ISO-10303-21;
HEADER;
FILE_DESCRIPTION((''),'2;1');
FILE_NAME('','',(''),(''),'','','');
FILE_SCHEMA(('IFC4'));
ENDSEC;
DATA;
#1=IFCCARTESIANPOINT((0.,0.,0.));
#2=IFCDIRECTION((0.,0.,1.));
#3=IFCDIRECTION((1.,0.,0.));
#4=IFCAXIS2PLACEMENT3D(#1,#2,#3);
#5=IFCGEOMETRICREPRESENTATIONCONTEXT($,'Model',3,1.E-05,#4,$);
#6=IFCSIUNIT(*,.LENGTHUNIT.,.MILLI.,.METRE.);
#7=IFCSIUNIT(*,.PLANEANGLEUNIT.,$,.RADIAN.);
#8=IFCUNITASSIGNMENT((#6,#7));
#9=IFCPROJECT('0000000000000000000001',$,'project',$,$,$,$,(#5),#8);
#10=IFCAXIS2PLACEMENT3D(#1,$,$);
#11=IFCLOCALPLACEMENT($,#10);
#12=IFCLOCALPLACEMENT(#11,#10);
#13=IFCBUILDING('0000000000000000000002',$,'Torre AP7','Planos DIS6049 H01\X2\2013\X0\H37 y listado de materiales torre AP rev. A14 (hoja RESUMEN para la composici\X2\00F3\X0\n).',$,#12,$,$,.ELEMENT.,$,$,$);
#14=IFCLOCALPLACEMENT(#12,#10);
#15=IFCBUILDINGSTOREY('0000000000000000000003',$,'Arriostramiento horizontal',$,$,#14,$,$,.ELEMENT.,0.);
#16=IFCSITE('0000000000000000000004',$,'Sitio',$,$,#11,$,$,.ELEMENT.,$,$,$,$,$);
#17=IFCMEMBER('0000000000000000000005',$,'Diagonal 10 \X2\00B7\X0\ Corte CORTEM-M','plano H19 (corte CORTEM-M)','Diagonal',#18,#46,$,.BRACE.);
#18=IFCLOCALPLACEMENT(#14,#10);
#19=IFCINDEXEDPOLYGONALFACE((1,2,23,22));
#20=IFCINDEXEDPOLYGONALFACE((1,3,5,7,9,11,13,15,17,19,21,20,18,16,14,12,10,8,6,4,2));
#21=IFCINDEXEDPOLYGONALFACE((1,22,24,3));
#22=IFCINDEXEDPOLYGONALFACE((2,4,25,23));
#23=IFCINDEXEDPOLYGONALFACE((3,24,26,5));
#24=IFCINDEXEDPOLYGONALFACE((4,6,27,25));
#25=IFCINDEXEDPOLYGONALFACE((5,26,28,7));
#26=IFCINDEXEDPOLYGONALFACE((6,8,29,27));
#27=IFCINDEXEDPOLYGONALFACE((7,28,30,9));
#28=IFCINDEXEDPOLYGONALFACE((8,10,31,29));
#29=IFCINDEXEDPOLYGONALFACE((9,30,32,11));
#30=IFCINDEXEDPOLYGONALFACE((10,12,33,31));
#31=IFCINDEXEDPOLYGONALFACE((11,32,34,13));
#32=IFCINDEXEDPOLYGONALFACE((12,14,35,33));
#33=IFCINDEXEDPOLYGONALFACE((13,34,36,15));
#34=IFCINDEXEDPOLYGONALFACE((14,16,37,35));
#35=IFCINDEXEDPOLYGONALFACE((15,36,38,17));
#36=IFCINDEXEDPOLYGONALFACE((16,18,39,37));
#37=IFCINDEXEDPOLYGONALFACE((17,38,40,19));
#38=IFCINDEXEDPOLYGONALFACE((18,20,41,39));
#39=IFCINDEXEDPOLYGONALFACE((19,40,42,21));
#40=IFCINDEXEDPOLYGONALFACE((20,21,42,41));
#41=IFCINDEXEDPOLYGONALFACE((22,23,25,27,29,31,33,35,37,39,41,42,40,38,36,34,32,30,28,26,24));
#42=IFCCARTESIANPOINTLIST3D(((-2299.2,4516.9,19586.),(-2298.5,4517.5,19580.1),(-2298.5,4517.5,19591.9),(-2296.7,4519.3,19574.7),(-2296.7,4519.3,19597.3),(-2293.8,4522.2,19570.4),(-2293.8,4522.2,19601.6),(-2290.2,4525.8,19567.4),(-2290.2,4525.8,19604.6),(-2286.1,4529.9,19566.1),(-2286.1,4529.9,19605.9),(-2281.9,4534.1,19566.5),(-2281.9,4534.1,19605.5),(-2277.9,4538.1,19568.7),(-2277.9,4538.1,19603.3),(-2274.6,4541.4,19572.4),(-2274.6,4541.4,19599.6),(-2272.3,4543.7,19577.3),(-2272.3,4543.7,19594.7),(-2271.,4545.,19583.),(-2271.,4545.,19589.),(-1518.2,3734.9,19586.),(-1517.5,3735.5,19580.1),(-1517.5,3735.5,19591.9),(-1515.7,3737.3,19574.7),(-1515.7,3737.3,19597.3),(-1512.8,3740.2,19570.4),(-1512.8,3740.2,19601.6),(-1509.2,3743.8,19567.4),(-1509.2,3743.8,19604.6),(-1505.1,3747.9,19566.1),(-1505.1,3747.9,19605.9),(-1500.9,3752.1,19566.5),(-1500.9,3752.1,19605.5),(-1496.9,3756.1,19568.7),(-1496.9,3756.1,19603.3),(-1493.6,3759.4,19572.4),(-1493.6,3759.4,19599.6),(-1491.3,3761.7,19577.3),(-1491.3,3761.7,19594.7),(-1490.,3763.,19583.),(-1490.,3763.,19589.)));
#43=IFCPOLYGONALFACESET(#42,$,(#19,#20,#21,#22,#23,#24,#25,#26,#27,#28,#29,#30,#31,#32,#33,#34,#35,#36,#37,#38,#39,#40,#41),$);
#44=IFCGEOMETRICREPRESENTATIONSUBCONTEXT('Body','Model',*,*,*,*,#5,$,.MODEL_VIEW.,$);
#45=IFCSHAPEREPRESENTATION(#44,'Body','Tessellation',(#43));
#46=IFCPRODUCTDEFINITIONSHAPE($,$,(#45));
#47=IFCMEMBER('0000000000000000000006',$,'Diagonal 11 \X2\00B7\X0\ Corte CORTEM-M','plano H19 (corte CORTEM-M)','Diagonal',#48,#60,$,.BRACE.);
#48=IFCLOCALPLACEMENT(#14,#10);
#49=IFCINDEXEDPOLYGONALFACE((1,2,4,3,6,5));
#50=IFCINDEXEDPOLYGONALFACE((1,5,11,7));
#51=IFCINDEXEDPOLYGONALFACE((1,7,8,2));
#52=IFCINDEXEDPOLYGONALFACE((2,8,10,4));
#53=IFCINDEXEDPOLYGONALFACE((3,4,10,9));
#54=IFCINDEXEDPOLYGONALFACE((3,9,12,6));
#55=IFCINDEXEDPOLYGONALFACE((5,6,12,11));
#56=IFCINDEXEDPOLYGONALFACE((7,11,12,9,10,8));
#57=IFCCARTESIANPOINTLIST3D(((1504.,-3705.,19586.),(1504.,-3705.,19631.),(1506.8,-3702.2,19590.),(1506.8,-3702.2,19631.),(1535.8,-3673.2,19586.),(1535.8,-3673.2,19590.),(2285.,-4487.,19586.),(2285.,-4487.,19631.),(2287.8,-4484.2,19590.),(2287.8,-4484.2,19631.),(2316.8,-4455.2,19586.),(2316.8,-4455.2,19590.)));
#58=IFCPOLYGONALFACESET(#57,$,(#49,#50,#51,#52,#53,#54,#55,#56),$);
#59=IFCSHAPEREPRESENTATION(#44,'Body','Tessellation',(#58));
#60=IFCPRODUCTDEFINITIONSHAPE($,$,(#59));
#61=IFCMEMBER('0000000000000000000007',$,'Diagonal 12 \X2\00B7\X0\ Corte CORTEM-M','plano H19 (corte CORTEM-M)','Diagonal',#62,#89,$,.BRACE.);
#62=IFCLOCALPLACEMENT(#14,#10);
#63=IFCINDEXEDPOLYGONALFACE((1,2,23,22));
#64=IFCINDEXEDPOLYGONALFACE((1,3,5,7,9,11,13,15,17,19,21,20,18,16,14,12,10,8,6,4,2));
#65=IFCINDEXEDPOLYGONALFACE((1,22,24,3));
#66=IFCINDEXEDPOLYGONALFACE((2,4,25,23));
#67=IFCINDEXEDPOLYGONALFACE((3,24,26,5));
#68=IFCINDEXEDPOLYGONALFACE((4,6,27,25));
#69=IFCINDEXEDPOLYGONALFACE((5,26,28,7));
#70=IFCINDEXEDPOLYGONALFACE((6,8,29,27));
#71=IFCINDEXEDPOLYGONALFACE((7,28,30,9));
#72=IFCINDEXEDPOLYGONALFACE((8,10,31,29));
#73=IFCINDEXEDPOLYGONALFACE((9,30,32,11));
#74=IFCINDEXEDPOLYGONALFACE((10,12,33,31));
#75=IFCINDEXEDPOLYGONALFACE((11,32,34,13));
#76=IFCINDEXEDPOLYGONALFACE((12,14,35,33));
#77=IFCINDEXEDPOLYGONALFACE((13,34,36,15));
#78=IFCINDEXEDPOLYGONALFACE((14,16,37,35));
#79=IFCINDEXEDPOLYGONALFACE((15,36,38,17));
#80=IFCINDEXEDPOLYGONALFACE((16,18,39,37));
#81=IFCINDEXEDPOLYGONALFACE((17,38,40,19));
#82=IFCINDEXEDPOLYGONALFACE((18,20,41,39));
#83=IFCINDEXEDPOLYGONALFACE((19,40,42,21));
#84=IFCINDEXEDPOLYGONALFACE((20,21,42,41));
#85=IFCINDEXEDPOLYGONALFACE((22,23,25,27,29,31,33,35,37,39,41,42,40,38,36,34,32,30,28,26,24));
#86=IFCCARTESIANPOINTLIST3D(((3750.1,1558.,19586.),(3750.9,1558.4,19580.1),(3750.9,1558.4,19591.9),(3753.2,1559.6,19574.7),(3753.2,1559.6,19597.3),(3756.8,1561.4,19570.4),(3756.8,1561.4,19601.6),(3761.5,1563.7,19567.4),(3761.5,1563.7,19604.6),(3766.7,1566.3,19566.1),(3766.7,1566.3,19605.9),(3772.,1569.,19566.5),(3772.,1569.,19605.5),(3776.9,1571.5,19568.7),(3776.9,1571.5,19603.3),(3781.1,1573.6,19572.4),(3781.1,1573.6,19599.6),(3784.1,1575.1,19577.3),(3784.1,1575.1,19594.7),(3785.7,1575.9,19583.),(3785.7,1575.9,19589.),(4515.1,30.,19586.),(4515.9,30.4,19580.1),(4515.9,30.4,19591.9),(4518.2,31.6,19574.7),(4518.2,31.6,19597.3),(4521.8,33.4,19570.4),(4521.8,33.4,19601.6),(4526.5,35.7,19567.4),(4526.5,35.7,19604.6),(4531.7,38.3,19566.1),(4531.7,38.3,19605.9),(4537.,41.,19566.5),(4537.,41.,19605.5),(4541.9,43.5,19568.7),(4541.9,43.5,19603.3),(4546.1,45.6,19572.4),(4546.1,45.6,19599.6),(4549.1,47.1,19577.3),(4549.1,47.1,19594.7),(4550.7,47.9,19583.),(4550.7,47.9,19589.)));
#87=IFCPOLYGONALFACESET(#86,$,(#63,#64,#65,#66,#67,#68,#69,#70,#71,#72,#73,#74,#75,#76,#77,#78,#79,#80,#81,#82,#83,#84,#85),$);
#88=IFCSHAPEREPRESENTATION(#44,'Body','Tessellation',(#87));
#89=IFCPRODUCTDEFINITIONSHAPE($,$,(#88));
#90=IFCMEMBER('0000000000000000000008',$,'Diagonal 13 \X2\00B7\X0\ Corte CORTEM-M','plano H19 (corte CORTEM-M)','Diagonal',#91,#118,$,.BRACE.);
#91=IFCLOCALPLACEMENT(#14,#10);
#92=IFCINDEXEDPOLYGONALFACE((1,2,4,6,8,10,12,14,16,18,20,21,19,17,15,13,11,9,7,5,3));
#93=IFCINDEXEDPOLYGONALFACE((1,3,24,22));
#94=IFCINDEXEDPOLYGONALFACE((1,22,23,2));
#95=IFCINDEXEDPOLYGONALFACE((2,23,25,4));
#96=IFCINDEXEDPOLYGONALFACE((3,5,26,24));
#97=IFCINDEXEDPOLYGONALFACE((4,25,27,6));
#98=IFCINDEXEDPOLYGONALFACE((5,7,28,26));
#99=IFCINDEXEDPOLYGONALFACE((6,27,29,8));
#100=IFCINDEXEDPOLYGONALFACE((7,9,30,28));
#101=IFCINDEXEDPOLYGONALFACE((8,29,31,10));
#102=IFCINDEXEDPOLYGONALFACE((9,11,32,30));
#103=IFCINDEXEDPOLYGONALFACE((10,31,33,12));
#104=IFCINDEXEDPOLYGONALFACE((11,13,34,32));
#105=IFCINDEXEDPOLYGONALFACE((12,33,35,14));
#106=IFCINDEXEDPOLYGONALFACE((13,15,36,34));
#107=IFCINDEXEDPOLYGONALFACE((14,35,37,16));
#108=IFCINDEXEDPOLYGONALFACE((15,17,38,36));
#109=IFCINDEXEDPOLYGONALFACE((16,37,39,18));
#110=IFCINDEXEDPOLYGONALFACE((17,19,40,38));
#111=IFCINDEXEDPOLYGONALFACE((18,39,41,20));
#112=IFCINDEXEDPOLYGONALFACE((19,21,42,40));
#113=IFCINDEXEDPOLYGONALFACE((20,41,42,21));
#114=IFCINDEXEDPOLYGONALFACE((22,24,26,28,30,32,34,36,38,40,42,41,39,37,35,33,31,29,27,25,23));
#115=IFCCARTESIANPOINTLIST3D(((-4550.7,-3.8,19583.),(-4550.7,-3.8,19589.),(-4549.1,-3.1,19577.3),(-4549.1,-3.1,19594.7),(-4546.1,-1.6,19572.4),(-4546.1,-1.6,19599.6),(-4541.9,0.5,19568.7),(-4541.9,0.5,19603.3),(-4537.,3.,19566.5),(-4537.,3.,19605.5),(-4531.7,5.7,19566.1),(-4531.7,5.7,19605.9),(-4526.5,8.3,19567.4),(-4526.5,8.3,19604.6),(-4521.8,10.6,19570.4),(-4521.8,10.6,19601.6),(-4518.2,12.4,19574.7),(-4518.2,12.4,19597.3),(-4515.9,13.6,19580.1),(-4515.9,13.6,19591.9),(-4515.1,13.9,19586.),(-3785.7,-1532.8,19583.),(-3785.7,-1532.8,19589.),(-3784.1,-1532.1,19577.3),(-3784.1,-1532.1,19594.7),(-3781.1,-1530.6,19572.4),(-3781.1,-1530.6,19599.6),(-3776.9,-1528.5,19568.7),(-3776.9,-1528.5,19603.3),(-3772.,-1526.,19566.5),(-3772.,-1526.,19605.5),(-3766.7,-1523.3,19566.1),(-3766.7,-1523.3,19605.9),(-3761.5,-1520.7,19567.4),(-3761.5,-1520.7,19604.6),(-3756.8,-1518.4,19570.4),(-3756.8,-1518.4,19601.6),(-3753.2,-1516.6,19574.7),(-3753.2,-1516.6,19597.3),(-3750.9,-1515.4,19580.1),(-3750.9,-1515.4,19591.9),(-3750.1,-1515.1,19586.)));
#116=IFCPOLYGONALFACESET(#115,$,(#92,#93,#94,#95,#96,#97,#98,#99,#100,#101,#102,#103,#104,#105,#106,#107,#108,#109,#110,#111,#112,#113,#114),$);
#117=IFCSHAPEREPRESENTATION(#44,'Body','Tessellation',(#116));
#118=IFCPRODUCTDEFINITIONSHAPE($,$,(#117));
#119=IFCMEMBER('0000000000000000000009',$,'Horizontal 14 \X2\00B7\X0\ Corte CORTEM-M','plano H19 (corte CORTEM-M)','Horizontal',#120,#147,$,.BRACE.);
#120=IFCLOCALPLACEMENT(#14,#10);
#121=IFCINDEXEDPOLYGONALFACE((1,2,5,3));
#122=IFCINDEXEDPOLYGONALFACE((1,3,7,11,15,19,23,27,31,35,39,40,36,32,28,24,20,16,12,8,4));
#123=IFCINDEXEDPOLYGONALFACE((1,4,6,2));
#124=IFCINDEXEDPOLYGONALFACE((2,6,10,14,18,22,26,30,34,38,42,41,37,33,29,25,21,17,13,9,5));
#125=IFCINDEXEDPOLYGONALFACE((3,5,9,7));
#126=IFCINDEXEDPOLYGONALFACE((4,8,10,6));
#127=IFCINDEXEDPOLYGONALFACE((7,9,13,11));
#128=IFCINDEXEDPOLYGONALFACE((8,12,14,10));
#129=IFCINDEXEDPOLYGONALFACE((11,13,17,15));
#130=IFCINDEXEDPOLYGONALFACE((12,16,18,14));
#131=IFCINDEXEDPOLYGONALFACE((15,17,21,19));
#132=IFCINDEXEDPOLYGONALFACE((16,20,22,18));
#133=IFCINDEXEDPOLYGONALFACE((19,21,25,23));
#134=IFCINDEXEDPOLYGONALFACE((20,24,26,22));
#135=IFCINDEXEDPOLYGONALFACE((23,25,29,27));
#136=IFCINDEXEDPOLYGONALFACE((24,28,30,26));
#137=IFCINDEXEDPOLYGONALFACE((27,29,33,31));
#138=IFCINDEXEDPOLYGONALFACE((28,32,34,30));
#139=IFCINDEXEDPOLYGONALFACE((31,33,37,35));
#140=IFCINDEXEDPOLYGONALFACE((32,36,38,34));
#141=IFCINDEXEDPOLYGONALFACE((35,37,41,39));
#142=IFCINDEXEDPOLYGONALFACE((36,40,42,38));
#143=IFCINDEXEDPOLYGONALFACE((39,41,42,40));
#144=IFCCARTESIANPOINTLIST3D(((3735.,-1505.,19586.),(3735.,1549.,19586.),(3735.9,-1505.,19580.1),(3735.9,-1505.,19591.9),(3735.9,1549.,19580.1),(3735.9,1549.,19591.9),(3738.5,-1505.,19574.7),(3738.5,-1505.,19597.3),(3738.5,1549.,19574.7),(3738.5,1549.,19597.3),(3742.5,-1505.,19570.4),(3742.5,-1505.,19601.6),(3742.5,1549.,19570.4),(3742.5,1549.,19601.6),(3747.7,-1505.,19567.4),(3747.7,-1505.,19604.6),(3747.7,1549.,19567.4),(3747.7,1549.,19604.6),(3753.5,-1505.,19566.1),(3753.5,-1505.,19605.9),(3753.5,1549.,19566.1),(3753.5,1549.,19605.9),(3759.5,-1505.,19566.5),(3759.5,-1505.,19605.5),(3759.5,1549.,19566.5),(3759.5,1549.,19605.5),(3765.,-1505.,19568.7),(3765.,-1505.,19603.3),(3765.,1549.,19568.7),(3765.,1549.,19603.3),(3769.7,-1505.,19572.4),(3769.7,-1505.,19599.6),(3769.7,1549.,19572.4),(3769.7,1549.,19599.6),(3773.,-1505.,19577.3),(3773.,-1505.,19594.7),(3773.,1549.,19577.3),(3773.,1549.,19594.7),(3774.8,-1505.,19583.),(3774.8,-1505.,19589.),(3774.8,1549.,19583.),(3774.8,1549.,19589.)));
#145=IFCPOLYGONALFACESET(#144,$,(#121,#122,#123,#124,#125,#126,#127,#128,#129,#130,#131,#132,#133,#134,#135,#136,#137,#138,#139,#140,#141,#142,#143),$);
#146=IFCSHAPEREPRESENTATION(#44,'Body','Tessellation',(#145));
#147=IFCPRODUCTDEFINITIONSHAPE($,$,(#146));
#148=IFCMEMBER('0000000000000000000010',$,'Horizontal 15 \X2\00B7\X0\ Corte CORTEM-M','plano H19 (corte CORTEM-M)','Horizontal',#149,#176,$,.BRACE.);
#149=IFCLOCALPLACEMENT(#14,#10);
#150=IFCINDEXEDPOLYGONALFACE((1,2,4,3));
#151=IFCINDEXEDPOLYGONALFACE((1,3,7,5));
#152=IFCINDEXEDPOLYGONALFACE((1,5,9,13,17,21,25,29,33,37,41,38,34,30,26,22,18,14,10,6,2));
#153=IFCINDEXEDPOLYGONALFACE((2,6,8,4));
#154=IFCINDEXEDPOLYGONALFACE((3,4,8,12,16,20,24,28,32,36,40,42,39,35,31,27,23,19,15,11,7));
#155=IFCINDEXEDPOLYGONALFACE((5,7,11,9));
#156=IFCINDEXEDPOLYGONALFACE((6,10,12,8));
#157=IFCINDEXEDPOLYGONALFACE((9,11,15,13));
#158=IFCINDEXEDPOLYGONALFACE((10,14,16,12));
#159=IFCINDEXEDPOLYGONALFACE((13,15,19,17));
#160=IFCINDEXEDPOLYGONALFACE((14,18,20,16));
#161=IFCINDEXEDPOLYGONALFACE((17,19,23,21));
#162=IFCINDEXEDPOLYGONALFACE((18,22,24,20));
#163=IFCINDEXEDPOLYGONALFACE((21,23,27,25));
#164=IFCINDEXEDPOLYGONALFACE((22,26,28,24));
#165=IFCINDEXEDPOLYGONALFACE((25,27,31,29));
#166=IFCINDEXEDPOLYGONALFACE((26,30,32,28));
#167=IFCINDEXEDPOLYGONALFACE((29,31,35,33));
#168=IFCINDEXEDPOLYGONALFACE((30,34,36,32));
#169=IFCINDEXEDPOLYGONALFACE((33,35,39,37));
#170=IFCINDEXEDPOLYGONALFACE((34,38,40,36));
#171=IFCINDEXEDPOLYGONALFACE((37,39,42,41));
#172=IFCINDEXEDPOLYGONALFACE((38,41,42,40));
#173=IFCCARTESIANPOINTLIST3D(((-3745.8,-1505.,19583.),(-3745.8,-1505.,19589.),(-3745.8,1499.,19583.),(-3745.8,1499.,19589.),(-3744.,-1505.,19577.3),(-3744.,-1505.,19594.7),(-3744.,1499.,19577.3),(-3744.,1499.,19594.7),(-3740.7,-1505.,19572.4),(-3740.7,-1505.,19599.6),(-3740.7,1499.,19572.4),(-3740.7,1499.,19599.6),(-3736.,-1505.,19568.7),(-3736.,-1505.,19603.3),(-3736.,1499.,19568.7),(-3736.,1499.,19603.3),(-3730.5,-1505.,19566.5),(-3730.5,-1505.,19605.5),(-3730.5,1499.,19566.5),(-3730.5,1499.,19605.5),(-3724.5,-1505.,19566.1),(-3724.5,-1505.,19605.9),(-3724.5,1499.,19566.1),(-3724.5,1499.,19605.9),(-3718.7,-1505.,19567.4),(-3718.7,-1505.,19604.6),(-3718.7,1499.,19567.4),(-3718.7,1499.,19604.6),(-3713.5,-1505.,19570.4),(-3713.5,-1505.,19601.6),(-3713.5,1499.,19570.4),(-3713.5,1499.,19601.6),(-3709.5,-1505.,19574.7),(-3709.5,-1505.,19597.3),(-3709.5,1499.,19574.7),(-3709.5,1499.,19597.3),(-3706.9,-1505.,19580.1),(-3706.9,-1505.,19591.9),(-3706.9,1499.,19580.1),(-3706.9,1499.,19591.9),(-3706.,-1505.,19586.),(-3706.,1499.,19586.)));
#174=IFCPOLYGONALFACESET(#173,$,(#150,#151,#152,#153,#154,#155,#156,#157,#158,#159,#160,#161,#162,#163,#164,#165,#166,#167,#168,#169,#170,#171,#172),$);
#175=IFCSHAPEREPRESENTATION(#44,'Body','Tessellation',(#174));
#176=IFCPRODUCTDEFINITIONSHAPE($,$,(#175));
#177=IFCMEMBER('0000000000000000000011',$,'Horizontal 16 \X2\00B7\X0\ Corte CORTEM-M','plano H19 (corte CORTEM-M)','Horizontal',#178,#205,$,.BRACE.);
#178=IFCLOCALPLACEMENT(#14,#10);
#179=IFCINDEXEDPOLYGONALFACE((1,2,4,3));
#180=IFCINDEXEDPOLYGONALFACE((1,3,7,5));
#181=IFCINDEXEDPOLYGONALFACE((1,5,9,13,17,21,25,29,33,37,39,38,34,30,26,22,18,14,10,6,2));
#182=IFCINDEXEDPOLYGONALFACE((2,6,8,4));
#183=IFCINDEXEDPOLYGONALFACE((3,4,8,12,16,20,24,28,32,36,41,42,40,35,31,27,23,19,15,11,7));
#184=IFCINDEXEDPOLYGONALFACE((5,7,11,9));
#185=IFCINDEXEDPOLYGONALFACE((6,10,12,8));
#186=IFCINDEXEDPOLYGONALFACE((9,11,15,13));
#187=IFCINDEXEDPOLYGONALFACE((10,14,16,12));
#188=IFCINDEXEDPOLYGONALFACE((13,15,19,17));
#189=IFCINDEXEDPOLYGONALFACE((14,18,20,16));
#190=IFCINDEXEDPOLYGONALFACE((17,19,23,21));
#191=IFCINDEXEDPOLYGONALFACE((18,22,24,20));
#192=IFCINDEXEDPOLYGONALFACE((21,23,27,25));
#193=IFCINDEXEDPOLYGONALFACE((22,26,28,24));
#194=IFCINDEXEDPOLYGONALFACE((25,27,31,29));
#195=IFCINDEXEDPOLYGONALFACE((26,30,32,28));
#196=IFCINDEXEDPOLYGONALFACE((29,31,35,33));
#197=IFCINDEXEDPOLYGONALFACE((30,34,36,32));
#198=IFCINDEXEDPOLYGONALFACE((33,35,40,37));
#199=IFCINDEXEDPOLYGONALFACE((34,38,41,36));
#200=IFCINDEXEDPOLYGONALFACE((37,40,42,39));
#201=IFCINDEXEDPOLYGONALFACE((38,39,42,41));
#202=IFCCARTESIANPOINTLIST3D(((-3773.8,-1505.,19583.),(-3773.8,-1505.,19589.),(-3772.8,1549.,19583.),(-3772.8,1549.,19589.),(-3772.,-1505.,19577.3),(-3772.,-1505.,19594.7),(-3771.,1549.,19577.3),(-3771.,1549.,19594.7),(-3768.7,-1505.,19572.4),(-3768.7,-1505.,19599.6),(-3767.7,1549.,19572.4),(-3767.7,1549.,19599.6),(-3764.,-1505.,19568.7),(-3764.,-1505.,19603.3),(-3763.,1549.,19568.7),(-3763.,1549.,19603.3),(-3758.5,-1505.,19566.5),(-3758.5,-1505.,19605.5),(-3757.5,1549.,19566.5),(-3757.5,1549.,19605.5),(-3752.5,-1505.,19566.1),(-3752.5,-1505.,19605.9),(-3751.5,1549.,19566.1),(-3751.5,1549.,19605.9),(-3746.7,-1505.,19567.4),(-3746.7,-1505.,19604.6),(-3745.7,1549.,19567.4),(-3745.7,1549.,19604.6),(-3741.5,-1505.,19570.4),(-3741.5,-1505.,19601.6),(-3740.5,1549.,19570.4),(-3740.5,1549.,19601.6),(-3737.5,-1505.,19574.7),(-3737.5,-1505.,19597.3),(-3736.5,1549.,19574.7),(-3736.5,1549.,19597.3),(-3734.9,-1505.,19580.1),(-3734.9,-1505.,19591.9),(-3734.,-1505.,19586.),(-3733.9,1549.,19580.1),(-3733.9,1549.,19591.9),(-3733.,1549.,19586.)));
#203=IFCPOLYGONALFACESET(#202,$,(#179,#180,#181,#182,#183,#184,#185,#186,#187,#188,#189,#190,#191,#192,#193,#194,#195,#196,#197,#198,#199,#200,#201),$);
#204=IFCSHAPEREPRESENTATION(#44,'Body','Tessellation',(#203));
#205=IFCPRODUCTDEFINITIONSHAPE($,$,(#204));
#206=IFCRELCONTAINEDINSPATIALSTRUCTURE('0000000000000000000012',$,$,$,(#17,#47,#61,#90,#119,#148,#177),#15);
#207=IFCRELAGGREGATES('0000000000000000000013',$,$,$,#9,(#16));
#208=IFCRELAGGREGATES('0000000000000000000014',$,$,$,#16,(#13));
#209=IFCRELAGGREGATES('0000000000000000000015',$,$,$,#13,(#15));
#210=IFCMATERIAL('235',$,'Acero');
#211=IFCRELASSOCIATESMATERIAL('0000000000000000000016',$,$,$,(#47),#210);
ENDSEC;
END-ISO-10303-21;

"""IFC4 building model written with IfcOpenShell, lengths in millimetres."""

from ifc_helpers import new_model, si_unit, frame, frame_2d, origin, origin_with_axes, place, context, subcontext, project, spatial, circle, l_section, extrude, material, element, save


model = new_model("IFC4")

# Units and contexts
model_context = context("Model", 3, precision=1e-05, world=origin_with_axes())
body_context = subcontext(model_context, "Body", "Model", "MODEL_VIEW")
ifc_project = project(units=[si_unit("LENGTHUNIT", "METRE", prefix="MILLI"), si_unit("PLANEANGLEUNIT", "RADIAN")], contexts=[model_context])

# Site, building, storey
site_placement = place(None, origin())
site = spatial("IfcSite", under=ifc_project, at=site_placement, Name="Sitio", CompositionType="ELEMENT")
building_placement = place(site_placement, origin())
building = spatial("IfcBuilding", under=site, at=building_placement, Name="Torre AP7", Description="Planos DIS6049 H01–H37 y listado de materiales torre AP rev. A14 (hoja RESUMEN para la composición).", CompositionType="ELEMENT")
storey_placement = place(building_placement, origin())
storey = spatial("IfcBuildingStorey", under=building, at=storey_placement, Name="Arriostramiento horizontal", CompositionType="ELEMENT", Elevation=0.0)

# Members
ifc_material = material(Name="235", Category="Acero")
member_1_placement = place(storey_placement, frame((-2285.0, 4531.0, 19586.0), z_axis=(0.706654, -0.707559, 0.0), x_axis=(-0.707559, -0.706654, 0.0)))
element("IfcMember", 1, at=member_1_placement, inside=storey, Name="Diagonal 10 · Corte CORTEM-M", Description="plano H19 (corte CORTEM-M)", ObjectType="Diagonal", PredefinedType="BRACE", context=body_context, shape_type="SweptSolid", body=[
    extrude(circle(Radius=20.0), None, (0.0, 0.0, 1.0), 1105.2),
])
member_2_placement = place(storey_placement, frame((1504.0, -3705.0, 19586.0), z_axis=(0.706654, -0.707559, 0.0), x_axis=(0.707559, 0.706654, 0.0)))
element("IfcMember", 2, at=member_2_placement, inside=storey, material=ifc_material, Name="Diagonal 11 · Corte CORTEM-M", Description="plano H19 (corte CORTEM-M)", ObjectType="Diagonal", PredefinedType="BRACE", context=body_context, shape_type="SweptSolid", body=[
    extrude(l_section(Depth=45.0, Width=45.0, Thickness=4.0, at=frame_2d((22.5, 22.5))), None, (0.0, 0.0, 1.0), 1105.2),
])
member_3_placement = place(storey_placement, frame((3768.0, 1567.0, 19586.0), z_axis=(0.447682, -0.894193, 0.0), x_axis=(-0.894193, -0.447682, 0.0)))
element("IfcMember", 3, at=member_3_placement, inside=storey, Name="Diagonal 12 · Corte CORTEM-M", Description="plano H19 (corte CORTEM-M)", ObjectType="Diagonal", PredefinedType="BRACE", context=body_context, shape_type="SweptSolid", body=[
    extrude(circle(Radius=20.0), None, (0.0, 0.0, 1.0), 1708.8),
])
member_4_placement = place(storey_placement, frame((-4533.0, 5.0, 19586.0), z_axis=(0.447448, -0.89431, 0.0), x_axis=(0.89431, 0.447448, 0.0)))
element("IfcMember", 4, at=member_4_placement, inside=storey, Name="Diagonal 13 · Corte CORTEM-M", Description="plano H19 (corte CORTEM-M)", ObjectType="Diagonal", PredefinedType="BRACE", context=body_context, shape_type="SweptSolid", body=[
    extrude(circle(Radius=20.0), None, (0.0, 0.0, 1.0), 1709.7),
])
member_5_placement = place(storey_placement, frame((3755.0, 1549.0, 19586.0), z_axis=(0.0, -1.0, 0.0), x_axis=(-1.0, 0.0, 0.0)))
element("IfcMember", 5, at=member_5_placement, inside=storey, Name="Horizontal 14 · Corte CORTEM-M", Description="plano H19 (corte CORTEM-M)", ObjectType="Horizontal", PredefinedType="BRACE", context=body_context, shape_type="SweptSolid", body=[
    extrude(circle(Radius=20.0), None, (0.0, 0.0, 1.0), 3054.0),
])
member_6_placement = place(storey_placement, frame((-3726.0, 1499.0, 19586.0), z_axis=(0.0, -1.0, 0.0), x_axis=(1.0, 0.0, 0.0)))
element("IfcMember", 6, at=member_6_placement, inside=storey, Name="Horizontal 15 · Corte CORTEM-M", Description="plano H19 (corte CORTEM-M)", ObjectType="Horizontal", PredefinedType="BRACE", context=body_context, shape_type="SweptSolid", body=[
    extrude(circle(Radius=20.0), None, (0.0, 0.0, 1.0), 3004.0),
])
member_7_placement = place(storey_placement, frame((-3753.0, 1549.0, 19586.0), z_axis=(-0.000327, -1.0, 0.0), x_axis=(1.0, -0.000327, 0.0)))
element("IfcMember", 7, at=member_7_placement, inside=storey, Name="Horizontal 16 · Corte CORTEM-M", Description="plano H19 (corte CORTEM-M)", ObjectType="Horizontal", PredefinedType="BRACE", context=body_context, shape_type="SweptSolid", body=[
    extrude(circle(Radius=20.0), None, (0.0, 0.0, 1.0), 3054.0),
])

save(model, "model.ifc")
